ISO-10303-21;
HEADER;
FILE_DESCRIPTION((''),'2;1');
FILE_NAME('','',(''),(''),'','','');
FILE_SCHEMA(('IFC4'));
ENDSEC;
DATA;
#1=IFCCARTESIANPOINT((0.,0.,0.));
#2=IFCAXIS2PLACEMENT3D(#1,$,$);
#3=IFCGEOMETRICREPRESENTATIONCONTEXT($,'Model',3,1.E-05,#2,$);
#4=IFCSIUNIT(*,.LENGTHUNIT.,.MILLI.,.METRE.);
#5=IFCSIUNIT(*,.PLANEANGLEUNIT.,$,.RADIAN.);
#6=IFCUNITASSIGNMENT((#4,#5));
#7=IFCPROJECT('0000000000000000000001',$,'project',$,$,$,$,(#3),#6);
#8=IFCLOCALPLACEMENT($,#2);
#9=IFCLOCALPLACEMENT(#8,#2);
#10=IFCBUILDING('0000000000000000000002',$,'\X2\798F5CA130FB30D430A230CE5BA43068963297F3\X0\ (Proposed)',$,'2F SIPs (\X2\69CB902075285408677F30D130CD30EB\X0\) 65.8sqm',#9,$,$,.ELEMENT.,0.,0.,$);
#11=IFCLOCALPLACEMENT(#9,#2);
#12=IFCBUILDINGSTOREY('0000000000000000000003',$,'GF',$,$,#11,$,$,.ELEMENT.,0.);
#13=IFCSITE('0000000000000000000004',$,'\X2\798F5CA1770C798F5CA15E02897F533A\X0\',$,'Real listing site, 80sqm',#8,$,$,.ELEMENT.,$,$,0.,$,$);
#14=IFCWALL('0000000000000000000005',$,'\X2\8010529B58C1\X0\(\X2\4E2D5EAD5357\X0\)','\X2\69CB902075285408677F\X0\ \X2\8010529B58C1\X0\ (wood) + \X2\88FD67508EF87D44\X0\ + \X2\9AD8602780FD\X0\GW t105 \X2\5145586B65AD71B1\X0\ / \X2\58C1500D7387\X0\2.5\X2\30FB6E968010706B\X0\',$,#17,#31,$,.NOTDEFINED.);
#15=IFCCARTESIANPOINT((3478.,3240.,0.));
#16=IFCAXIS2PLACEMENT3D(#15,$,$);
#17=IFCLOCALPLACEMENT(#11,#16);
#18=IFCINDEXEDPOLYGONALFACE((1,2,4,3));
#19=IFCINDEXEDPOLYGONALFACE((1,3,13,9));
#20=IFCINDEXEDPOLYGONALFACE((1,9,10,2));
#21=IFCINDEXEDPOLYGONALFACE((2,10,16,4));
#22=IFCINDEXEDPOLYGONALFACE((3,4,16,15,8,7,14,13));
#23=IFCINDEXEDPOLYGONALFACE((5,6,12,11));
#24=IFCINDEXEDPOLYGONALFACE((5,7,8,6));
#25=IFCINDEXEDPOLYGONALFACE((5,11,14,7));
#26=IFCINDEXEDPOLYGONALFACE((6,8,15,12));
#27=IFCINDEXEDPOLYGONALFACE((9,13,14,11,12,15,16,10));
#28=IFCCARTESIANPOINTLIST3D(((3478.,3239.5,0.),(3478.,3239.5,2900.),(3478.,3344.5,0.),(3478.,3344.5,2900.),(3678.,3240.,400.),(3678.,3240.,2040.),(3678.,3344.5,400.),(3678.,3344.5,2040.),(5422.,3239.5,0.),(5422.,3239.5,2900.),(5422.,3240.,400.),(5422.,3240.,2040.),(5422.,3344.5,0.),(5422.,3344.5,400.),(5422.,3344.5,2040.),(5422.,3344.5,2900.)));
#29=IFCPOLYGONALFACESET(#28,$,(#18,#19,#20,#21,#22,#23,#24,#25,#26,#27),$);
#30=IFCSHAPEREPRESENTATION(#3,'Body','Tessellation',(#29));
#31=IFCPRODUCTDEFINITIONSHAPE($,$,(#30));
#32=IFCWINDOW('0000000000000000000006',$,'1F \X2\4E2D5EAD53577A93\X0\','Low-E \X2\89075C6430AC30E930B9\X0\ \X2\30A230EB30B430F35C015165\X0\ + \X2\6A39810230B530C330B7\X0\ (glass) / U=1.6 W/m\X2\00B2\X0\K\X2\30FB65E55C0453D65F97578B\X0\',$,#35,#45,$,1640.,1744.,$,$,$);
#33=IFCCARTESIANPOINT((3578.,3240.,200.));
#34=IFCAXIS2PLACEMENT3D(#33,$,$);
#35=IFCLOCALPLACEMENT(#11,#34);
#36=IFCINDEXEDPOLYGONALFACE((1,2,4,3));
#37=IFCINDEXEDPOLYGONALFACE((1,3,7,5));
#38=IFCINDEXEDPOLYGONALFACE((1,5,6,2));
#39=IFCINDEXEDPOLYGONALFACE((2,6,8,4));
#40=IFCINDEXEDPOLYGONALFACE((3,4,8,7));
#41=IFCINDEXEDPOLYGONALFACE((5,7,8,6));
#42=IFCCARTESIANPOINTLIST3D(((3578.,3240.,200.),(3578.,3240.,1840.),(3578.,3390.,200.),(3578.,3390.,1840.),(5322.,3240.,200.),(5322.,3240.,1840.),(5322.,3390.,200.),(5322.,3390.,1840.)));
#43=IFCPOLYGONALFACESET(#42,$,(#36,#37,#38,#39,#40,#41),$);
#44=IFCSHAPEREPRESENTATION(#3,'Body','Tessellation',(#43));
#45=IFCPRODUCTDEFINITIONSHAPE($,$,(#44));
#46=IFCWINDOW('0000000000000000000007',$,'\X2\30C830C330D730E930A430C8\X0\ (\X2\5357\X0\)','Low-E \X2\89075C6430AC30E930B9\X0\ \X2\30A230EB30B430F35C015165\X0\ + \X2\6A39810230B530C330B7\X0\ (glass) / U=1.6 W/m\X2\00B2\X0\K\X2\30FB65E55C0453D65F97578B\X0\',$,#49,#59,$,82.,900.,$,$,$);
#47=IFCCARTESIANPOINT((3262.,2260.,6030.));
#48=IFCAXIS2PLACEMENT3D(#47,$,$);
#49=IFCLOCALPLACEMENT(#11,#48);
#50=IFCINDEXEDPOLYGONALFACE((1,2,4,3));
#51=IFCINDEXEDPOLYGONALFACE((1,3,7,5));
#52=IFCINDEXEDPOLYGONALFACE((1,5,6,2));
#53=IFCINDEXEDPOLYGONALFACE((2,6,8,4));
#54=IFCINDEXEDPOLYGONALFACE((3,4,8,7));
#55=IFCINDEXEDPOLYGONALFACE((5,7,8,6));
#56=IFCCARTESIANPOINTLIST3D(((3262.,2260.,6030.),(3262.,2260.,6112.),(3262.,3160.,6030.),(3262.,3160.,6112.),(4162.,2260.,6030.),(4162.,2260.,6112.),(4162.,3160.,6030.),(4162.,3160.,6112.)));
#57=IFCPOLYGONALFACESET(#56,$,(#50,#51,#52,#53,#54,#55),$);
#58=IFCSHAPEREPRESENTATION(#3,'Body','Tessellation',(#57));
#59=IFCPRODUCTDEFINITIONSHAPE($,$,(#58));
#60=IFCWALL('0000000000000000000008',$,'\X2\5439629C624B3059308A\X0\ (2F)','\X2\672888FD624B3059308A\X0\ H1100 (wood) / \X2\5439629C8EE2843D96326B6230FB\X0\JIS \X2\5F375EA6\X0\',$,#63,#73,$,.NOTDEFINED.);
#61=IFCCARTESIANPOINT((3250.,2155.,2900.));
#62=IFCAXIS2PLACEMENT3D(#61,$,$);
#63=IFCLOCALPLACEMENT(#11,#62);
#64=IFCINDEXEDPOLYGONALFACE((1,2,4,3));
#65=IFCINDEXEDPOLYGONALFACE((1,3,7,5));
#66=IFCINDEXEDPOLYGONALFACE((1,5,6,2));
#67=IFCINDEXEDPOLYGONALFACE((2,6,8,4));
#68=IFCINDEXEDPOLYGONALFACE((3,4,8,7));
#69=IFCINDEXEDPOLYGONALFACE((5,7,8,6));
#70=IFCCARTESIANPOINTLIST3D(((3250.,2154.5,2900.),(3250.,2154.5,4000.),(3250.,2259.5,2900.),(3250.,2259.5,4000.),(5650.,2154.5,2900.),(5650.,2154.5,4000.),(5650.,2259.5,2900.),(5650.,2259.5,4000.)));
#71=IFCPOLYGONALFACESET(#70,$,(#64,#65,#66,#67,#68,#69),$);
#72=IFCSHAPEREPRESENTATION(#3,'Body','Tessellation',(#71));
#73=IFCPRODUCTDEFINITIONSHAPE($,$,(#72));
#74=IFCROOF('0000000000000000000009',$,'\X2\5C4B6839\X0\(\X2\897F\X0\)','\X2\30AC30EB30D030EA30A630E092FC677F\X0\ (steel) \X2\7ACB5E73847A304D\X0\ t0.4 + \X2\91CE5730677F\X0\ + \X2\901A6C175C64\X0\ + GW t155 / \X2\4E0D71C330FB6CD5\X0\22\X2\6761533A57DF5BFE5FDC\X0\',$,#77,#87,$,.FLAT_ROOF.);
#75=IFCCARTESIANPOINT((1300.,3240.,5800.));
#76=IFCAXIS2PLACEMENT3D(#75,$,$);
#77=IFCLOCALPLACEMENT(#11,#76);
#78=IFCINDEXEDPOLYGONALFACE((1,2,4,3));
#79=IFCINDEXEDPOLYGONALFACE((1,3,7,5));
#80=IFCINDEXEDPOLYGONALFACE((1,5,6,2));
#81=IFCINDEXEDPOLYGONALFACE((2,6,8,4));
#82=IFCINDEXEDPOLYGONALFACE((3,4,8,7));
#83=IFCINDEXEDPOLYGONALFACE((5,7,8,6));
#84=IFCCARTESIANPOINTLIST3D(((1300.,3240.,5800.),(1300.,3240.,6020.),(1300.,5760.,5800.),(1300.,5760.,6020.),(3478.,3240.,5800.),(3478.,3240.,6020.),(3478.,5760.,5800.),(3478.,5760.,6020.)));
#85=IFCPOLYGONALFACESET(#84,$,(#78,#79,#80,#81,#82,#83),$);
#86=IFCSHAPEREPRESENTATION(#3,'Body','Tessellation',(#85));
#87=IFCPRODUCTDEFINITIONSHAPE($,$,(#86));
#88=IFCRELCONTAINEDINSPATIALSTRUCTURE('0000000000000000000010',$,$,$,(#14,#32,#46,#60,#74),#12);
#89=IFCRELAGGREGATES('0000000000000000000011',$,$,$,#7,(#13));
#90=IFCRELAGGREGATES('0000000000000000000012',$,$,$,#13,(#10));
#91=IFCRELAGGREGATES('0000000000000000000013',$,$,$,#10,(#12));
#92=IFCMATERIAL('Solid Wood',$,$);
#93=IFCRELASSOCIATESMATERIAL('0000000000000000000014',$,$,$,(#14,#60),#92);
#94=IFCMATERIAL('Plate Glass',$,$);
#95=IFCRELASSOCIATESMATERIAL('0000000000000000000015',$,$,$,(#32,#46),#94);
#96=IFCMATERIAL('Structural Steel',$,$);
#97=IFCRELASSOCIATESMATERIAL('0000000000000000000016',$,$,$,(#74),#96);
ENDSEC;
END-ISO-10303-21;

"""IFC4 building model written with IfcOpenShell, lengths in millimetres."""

from ifc_helpers import new_model, si_unit, frame, frame_2d, origin, place, context, project, spatial, rectangle, extrude, material, element, fill, save


model = new_model("IFC4")

# Units and contexts
model_context = context("Model", 3, precision=1e-05, world=origin())
ifc_project = project(units=[si_unit("LENGTHUNIT", "METRE", prefix="MILLI"), si_unit("PLANEANGLEUNIT", "RADIAN")], contexts=[model_context])

# Site, building, storey
site_placement = place(None, origin())
site = spatial("IfcSite", under=ifc_project, at=site_placement, Name="福岡県福岡市西区", ObjectType="Real listing site, 80sqm", CompositionType="ELEMENT", RefElevation=0.0)
building_placement = place(site_placement, origin())
building = spatial("IfcBuilding", under=site, at=building_placement, Name="福岡・ピアノ室と防音 (Proposed)", ObjectType="2F SIPs (構造用合板パネル) 65.8sqm", CompositionType="ELEMENT", ElevationOfRefHeight=0.0, ElevationOfTerrain=0.0)
storey_placement = place(building_placement, origin())
storey = spatial("IfcBuildingStorey", under=building, at=storey_placement, Name="GF", CompositionType="ELEMENT", Elevation=0.0)

# Shared definitions
ifc_material_1 = material(Name="Solid Wood")

# Wall, opening, window
wall_1_placement = place(storey_placement, frame((3478.0, 3240.0, 0.0)))
wall_1 = element("IfcWall", 1, at=wall_1_placement, inside=storey, material=ifc_material_1, Name="耐力壁(中庭南)", Description="構造用合板 耐力壁 (wood) + 製材軸組 + 高性能GW t105 充填断熱 / 壁倍率2.5・準耐火", PredefinedType="NOTDEFINED", context=model_context, shape_type="SweptSolid", body=[
    extrude(rectangle(XDim=1944.0, YDim=105.0, at=frame_2d((972.0, 52.0))), frame((3478.0, 3240.0, 0.0)), (0.0, 0.0, 1.0), 2900.0),
])
opening_placement = place(storey_placement, frame((3578.0, 3240.0, 200.0)))
opening = element("IfcOpeningElement", 2, at=opening_placement, cuts=wall_1, PredefinedType="NOTDEFINED", context=model_context, shape_type="SweptSolid", body=[
    extrude(rectangle(XDim=1744.0, YDim=150.0, at=frame_2d((872.0, 75.0))), frame((3578.0, 3240.0, 200.0)), (0.0, 0.0, 1.0), 1640.0),
])
ifc_material_2 = material(Name="Plate Glass")
window_1_placement = place(storey_placement, frame((3578.0, 3240.0, 200.0)))
window_1 = element("IfcWindow", 3, at=window_1_placement, inside=storey, material=ifc_material_2, Name="1F 中庭南窓", Description="Low-E 複層ガラス アルゴン封入 + 樹脂サッシ (glass) / U=1.6 W/m²K・日射取得型", OverallHeight=1640.0, OverallWidth=1744.0, context=model_context, shape_type="SweptSolid", body=[
    extrude(rectangle(XDim=1744.0, YDim=150.0, at=frame_2d((872.0, 75.0))), frame((3578.0, 3240.0, 200.0)), (0.0, 0.0, 1.0), 1640.0),
])
fill(opening, window_1)

# Window
window_2_placement = place(storey_placement, frame((3262.0, 2260.0, 6030.0)))
element("IfcWindow", 4, at=window_2_placement, inside=storey, material=ifc_material_2, Name="トップライト (南)", Description="Low-E 複層ガラス アルゴン封入 + 樹脂サッシ (glass) / U=1.6 W/m²K・日射取得型", OverallHeight=82.0, OverallWidth=900.0, context=model_context, shape_type="SweptSolid", body=[
    extrude(rectangle(XDim=900.0, YDim=900.0, at=frame_2d((450.0, 450.0))), frame((3262.0, 2260.0, 6030.0)), (0.0, 0.0, 1.0), 82.0),
])

# Wall
wall_2_placement = place(storey_placement, frame((3250.0, 2155.0, 2900.0)))
element("IfcWall", 5, at=wall_2_placement, inside=storey, material=ifc_material_1, Name="吹抜手すり (2F)", Description="木製手すり H1100 (wood) / 吹抜転落防止・JIS 強度", PredefinedType="NOTDEFINED", context=model_context, shape_type="SweptSolid", body=[
    extrude(rectangle(XDim=2400.0, YDim=105.0, at=frame_2d((1200.0, 52.0))), frame((3250.0, 2155.0, 2900.0)), (0.0, 0.0, 1.0), 1100.0),
])

# Roof
ifc_material_3 = material(Name="Structural Steel")
for number, where, name in (
    (6, (1300.0, 3240.0, 5800.0), "屋根(西)"),
):
    element("IfcRoof", number, at=place(storey_placement, frame(where)), inside=storey, material=ifc_material_3, Name=name, Description="ガルバリウム鋼板 (steel) 立平葺き t0.4 + 野地板 + 通気層 + GW t155 / 不燃・法22条区域対応", PredefinedType="FLAT_ROOF", context=model_context, shape_type="SweptSolid", body=[
        extrude(rectangle(XDim=2178.0, YDim=2520.0, at=frame_2d((1089.0, 1260.0))), frame((1300.0, 3240.0, 5800.0)), (0.0, 0.0, 1.0), 220.0),
    ])

save(model, "model.ifc")
